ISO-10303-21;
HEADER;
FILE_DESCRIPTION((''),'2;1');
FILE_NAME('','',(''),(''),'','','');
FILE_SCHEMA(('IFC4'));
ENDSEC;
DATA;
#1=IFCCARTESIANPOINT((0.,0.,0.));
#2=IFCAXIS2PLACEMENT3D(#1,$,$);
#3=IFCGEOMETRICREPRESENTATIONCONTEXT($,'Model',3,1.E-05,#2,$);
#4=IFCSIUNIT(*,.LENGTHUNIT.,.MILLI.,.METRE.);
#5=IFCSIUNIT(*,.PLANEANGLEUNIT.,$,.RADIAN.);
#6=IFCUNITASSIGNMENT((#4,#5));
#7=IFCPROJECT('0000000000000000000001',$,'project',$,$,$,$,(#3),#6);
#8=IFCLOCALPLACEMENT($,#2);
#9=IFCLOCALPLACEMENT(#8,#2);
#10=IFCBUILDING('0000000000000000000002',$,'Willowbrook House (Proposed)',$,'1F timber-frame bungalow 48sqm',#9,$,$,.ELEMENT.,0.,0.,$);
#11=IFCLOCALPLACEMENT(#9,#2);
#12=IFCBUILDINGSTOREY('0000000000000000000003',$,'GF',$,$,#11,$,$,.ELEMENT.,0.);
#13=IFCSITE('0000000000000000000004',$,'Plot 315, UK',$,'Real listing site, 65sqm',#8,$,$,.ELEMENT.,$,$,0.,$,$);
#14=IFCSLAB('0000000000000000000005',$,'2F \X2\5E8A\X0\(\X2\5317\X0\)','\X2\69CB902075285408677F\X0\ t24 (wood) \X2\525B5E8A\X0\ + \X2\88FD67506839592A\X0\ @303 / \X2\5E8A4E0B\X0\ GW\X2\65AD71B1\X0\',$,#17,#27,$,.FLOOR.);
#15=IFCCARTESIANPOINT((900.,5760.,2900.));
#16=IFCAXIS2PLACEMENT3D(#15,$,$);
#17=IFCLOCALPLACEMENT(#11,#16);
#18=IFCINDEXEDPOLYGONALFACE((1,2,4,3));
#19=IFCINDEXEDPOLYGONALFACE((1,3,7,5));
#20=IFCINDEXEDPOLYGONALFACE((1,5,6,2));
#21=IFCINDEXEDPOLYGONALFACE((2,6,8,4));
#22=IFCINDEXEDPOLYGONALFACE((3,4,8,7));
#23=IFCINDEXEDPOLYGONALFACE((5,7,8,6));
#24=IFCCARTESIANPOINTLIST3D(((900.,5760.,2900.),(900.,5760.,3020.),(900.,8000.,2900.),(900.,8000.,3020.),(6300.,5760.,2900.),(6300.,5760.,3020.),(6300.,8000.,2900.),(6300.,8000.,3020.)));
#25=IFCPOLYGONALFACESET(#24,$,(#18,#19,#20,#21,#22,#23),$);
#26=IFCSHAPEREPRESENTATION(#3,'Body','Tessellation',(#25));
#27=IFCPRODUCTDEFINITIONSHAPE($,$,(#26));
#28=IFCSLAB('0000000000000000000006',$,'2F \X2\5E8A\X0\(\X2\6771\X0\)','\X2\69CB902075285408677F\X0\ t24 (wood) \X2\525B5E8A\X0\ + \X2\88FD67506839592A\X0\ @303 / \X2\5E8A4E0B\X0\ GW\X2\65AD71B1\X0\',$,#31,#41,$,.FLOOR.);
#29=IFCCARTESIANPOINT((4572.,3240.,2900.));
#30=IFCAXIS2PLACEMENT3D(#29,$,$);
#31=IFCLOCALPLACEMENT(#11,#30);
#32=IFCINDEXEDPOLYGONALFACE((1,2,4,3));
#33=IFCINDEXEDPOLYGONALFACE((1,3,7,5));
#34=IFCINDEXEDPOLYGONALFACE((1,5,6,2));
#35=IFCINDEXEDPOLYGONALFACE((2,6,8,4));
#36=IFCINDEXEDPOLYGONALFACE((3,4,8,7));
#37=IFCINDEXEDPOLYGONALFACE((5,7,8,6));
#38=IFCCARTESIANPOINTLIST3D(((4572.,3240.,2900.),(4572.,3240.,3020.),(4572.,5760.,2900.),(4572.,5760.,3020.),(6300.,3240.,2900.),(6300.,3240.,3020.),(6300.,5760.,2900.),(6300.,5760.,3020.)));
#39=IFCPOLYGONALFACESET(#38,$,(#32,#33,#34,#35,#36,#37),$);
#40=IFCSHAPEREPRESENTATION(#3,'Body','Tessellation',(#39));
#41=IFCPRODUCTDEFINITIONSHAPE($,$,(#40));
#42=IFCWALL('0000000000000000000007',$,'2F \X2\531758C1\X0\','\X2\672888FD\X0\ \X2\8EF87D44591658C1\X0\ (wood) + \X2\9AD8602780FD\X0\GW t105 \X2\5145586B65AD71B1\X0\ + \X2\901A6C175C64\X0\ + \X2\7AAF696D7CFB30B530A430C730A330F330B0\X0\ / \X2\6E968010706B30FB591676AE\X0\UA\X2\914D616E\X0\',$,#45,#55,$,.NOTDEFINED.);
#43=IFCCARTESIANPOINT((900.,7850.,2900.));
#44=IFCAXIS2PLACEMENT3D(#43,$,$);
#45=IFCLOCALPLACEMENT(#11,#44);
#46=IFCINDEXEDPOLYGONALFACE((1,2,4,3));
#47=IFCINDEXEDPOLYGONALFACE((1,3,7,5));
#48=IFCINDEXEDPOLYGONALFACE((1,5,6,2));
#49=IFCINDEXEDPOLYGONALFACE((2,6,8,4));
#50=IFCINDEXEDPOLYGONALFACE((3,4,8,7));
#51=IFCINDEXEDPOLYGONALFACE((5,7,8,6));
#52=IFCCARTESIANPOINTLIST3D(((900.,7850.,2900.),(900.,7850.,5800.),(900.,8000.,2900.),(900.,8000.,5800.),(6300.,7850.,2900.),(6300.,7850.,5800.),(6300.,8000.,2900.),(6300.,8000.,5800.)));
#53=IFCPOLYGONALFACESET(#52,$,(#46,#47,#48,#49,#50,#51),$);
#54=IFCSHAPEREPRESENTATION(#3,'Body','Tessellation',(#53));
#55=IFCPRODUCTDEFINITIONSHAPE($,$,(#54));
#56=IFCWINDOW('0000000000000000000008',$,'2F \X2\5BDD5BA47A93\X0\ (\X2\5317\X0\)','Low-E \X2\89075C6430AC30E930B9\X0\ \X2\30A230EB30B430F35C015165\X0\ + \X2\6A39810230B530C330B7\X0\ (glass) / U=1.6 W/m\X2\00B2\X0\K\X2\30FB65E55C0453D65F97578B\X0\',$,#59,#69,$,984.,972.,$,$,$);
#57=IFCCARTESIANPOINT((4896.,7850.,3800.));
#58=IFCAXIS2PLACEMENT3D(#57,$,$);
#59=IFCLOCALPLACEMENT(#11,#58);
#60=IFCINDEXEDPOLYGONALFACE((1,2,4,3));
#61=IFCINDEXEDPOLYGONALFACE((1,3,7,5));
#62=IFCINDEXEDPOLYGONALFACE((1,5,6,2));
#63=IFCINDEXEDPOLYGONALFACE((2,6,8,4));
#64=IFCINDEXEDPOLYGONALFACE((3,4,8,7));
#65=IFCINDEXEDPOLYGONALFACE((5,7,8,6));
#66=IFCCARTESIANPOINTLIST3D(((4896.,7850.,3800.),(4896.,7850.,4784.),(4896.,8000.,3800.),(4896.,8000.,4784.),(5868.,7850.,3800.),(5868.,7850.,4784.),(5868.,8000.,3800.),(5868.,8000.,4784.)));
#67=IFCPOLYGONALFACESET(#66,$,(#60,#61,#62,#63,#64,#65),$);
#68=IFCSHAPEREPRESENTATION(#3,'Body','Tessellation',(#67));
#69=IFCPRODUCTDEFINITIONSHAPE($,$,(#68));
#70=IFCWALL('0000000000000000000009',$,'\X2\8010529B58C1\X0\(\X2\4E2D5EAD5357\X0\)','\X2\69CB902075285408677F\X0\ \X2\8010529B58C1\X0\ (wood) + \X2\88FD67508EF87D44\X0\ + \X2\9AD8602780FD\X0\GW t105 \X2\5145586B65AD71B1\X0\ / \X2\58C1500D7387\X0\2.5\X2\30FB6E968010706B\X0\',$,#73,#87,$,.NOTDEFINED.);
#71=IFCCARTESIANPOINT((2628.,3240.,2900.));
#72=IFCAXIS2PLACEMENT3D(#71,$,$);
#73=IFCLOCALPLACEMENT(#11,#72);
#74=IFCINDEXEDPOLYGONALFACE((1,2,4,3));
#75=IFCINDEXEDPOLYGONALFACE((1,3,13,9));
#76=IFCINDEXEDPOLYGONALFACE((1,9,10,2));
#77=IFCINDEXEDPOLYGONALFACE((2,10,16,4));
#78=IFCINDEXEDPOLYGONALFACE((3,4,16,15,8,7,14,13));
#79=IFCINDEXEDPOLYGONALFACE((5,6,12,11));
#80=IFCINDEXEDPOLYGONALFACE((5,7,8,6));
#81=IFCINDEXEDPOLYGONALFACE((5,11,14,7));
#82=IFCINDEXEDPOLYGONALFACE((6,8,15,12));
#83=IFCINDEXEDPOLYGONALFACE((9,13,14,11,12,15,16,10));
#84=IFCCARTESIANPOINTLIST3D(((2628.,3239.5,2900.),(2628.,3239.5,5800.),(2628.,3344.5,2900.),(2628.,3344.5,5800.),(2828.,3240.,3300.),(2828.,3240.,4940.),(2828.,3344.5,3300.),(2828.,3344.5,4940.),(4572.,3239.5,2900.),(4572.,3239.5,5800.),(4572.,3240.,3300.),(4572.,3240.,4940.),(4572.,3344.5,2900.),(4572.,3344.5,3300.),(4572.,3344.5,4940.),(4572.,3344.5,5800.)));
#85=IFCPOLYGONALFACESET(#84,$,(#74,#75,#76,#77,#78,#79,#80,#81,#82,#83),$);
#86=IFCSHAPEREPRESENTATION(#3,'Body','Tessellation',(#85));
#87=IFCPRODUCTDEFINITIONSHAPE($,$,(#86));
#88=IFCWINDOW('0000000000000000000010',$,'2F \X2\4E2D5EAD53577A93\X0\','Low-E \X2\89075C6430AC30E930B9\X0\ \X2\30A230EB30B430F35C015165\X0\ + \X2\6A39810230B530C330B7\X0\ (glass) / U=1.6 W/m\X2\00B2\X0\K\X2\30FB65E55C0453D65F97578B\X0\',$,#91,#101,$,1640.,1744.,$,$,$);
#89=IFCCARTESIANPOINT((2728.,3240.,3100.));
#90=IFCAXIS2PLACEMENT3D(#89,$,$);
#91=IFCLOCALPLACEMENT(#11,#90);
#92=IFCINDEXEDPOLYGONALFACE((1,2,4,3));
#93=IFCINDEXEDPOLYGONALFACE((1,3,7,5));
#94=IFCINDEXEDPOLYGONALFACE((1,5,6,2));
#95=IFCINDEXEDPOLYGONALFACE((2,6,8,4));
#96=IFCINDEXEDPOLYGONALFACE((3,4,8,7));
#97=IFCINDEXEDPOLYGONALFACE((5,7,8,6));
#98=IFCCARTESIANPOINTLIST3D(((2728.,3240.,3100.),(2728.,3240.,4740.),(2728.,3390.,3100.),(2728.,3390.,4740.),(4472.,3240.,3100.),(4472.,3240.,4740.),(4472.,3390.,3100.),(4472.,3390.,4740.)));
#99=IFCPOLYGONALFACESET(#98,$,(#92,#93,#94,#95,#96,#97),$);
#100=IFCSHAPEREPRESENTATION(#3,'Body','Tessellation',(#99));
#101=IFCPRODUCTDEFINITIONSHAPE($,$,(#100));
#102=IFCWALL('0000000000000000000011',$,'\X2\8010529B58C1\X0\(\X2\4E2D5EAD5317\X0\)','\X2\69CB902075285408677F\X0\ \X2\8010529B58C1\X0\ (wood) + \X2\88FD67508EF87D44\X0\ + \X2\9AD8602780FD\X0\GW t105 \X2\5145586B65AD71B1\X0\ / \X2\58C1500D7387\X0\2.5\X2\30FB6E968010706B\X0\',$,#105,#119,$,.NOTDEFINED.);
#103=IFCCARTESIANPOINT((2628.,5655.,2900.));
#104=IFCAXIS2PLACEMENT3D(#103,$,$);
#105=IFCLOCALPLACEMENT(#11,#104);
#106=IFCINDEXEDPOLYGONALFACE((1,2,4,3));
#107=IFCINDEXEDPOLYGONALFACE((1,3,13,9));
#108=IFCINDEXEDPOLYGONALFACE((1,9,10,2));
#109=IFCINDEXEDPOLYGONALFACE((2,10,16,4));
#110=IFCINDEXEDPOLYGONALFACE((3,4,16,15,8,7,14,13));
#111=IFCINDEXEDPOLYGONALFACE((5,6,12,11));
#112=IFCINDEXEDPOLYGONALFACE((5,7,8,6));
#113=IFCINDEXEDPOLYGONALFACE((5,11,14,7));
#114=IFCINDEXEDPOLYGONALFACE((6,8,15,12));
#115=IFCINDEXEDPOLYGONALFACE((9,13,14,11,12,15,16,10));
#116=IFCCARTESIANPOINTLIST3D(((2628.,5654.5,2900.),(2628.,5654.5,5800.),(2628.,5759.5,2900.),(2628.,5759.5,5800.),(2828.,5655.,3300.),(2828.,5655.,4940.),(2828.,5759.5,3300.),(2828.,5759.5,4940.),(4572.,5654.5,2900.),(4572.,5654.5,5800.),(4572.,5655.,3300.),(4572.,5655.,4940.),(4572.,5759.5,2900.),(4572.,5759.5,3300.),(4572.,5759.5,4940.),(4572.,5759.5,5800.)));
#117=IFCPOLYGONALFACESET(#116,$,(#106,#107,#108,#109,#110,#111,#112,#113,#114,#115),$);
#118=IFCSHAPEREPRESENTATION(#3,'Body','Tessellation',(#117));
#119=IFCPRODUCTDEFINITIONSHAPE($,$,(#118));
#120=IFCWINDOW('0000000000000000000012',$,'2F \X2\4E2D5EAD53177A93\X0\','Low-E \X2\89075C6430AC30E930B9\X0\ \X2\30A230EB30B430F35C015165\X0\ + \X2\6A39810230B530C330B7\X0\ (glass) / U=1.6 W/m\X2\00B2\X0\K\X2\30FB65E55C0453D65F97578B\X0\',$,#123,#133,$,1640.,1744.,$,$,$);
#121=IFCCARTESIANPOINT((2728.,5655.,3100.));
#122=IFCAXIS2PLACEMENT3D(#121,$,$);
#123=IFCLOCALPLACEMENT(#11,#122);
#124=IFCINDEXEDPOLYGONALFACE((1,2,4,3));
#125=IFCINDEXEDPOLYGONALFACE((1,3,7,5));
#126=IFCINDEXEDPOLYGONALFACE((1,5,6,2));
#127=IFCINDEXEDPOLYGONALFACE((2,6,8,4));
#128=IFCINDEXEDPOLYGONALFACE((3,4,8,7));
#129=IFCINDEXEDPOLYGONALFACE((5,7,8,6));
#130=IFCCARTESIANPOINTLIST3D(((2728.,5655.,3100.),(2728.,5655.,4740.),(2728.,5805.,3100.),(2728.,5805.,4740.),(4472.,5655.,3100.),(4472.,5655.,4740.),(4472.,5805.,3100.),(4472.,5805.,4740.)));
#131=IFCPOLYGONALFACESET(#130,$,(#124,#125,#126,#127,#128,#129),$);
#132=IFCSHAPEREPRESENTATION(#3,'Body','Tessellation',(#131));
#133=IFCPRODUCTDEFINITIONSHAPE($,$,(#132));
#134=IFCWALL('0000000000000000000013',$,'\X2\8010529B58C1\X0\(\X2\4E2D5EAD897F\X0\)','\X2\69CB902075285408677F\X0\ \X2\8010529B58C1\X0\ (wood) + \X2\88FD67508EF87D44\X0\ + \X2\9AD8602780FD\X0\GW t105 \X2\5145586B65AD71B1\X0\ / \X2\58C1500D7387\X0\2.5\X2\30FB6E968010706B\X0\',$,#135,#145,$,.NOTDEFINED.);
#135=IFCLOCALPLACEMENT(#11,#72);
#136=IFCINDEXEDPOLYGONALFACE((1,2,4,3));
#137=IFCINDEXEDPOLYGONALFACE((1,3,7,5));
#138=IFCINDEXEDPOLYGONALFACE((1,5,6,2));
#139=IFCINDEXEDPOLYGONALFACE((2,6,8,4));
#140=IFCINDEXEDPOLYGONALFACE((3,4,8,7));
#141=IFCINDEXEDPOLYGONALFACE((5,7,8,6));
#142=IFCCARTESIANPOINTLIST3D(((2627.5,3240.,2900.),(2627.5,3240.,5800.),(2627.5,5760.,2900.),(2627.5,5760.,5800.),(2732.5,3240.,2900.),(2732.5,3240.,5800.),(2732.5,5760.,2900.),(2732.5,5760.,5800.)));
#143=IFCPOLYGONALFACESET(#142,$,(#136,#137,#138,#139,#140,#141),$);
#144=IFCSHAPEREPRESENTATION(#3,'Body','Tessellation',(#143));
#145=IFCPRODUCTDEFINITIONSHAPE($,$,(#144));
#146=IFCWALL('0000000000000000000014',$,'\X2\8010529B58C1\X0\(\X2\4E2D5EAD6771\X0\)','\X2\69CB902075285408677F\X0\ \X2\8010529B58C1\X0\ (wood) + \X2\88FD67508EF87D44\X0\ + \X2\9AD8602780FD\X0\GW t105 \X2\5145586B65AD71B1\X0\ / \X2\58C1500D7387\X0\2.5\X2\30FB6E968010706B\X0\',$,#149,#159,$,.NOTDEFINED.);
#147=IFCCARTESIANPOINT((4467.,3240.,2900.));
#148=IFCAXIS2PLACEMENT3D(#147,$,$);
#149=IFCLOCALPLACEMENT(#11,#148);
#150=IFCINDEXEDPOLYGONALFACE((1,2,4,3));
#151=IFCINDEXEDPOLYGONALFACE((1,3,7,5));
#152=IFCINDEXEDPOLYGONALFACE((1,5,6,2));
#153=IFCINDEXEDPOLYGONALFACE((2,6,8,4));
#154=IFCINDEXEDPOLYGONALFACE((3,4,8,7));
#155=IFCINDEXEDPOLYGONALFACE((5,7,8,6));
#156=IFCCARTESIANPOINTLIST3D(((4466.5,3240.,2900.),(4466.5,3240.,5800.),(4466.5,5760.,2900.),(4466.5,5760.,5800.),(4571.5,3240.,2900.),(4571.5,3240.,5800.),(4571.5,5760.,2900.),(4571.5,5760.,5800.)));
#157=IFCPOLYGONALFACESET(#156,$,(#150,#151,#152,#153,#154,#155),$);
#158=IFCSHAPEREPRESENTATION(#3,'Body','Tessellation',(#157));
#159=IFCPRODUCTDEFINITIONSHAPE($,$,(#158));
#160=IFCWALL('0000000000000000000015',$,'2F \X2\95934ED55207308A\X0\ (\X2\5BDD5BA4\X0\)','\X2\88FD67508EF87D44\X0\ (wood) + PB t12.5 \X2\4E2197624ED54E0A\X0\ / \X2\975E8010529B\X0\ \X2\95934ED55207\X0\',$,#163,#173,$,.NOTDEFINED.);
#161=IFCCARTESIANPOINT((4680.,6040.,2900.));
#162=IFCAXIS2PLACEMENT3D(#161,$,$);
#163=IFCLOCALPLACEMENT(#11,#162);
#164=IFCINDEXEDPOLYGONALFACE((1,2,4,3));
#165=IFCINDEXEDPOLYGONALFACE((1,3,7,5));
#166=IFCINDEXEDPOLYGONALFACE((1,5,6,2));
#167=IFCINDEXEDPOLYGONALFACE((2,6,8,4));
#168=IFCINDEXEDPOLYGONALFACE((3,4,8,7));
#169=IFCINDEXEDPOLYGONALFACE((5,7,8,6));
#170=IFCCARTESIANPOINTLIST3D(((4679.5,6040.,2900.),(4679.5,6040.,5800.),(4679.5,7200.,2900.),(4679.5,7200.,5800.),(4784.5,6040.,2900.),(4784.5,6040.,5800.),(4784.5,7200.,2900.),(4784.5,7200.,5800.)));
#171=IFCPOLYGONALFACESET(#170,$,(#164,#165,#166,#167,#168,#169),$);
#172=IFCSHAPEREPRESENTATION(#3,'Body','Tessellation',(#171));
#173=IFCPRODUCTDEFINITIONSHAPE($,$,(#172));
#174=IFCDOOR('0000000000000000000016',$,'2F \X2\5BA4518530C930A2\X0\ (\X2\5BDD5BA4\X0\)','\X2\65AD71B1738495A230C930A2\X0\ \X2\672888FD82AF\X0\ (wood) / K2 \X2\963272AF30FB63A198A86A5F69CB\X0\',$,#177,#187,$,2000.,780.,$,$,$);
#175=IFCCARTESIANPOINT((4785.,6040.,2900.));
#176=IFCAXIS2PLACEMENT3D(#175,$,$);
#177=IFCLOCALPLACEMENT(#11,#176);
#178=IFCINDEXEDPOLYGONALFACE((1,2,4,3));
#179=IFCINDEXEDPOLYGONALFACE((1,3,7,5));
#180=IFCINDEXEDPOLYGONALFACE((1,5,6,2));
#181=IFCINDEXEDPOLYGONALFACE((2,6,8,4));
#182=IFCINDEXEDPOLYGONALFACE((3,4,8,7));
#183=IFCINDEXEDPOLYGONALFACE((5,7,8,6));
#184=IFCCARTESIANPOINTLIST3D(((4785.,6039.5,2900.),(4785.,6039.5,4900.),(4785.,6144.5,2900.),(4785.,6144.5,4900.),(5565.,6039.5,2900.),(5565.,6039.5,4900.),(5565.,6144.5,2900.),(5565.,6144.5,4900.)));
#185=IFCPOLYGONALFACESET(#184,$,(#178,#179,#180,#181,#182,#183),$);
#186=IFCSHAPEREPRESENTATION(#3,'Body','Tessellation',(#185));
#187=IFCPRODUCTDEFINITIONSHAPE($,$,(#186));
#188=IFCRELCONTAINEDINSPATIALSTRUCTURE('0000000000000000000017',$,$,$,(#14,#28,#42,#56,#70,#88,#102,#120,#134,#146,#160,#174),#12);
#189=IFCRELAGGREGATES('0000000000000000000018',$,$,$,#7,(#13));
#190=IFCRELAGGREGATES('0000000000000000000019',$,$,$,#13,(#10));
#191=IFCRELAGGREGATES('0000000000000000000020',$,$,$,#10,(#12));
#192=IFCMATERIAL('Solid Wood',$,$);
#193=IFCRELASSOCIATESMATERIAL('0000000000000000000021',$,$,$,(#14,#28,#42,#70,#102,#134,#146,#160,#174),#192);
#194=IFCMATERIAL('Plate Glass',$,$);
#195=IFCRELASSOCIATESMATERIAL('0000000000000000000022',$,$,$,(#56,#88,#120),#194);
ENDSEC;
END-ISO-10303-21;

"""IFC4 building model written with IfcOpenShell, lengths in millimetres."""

from ifc_helpers import new_model, si_unit, frame, frame_2d, origin, place, context, project, spatial, rectangle, extrude, material, element, fill, save


model = new_model("IFC4")

# Units and contexts
model_context = context("Model", 3, precision=1e-05, world=origin())
ifc_project = project(units=[si_unit("LENGTHUNIT", "METRE", prefix="MILLI"), si_unit("PLANEANGLEUNIT", "RADIAN")], contexts=[model_context])

# Site, building, storey
site_placement = place(None, origin())
site = spatial("IfcSite", under=ifc_project, at=site_placement, Name="Plot 315, UK", ObjectType="Real listing site, 65sqm", CompositionType="ELEMENT", RefElevation=0.0)
building_placement = place(site_placement, origin())
building = spatial("IfcBuilding", under=site, at=building_placement, Name="Willowbrook House (Proposed)", ObjectType="1F timber-frame bungalow 48sqm", CompositionType="ELEMENT", ElevationOfRefHeight=0.0, ElevationOfTerrain=0.0)
storey_placement = place(building_placement, origin())
storey = spatial("IfcBuildingStorey", under=building, at=storey_placement, Name="GF", CompositionType="ELEMENT", Elevation=0.0)

# Slabs
ifc_material_1 = material(Name="Solid Wood")
slab_1_placement = place(storey_placement, frame((900.0, 5760.0, 2900.0)))
element("IfcSlab", 1, at=slab_1_placement, inside=storey, material=ifc_material_1, Name="2F 床(北)", Description="構造用合板 t24 (wood) 剛床 + 製材根太 @303 / 床下 GW断熱", PredefinedType="FLOOR", context=model_context, shape_type="SweptSolid", body=[
    extrude(rectangle(XDim=5400.0, YDim=2240.0, at=frame_2d((2700.0, 1120.0))), frame((900.0, 5760.0, 2900.0)), (0.0, 0.0, 1.0), 120.0),
])
slab_2_placement = place(storey_placement, frame((4572.0, 3240.0, 2900.0)))
element("IfcSlab", 2, at=slab_2_placement, inside=storey, material=ifc_material_1, Name="2F 床(東)", Description="構造用合板 t24 (wood) 剛床 + 製材根太 @303 / 床下 GW断熱", PredefinedType="FLOOR", context=model_context, shape_type="SweptSolid", body=[
    extrude(rectangle(XDim=1728.0, YDim=2520.0, at=frame_2d((864.0, 1260.0))), frame((4572.0, 3240.0, 2900.0)), (0.0, 0.0, 1.0), 120.0),
])

# Walls, openings, windows
wall_1_placement = place(storey_placement, frame((900.0, 7850.0, 2900.0)))
wall_1 = element("IfcWall", 3, at=wall_1_placement, inside=storey, material=ifc_material_1, Name="2F 北壁", Description="木製 軸組外壁 (wood) + 高性能GW t105 充填断熱 + 通気層 + 窯業系サイディング / 準耐火・外皮UA配慮", PredefinedType="NOTDEFINED", context=model_context, shape_type="SweptSolid", body=[
    extrude(rectangle(XDim=5400.0, YDim=150.0, at=frame_2d((2700.0, 75.0))), frame((900.0, 7850.0, 2900.0)), (0.0, 0.0, 1.0), 2900.0),
])
opening_1_placement = place(storey_placement, frame((4896.0, 7850.0, 3800.0)))
opening_1 = element("IfcOpeningElement", 4, at=opening_1_placement, cuts=wall_1, PredefinedType="NOTDEFINED", context=model_context, shape_type="SweptSolid", body=[
    extrude(rectangle(XDim=972.0, YDim=150.0, at=frame_2d((486.0, 75.0))), frame((4896.0, 7850.0, 3800.0)), (0.0, 0.0, 1.0), 984.0),
])
ifc_material_2 = material(Name="Plate Glass")
window_1_placement = place(storey_placement, frame((4896.0, 7850.0, 3800.0)))
window_1 = element("IfcWindow", 5, at=window_1_placement, inside=storey, material=ifc_material_2, Name="2F 寝室窓 (北)", Description="Low-E 複層ガラス アルゴン封入 + 樹脂サッシ (glass) / U=1.6 W/m²K・日射取得型", OverallHeight=984.0, OverallWidth=972.0, context=model_context, shape_type="SweptSolid", body=[
    extrude(rectangle(XDim=972.0, YDim=150.0, at=frame_2d((486.0, 75.0))), frame((4896.0, 7850.0, 3800.0)), (0.0, 0.0, 1.0), 984.0),
])
fill(opening_1, window_1)
wall_2_placement = place(storey_placement, frame((2628.0, 3240.0, 2900.0)))
wall_2 = element("IfcWall", 6, at=wall_2_placement, inside=storey, material=ifc_material_1, Name="耐力壁(中庭南)", Description="構造用合板 耐力壁 (wood) + 製材軸組 + 高性能GW t105 充填断熱 / 壁倍率2.5・準耐火", PredefinedType="NOTDEFINED", context=model_context, shape_type="SweptSolid", body=[
    extrude(rectangle(XDim=1944.0, YDim=105.0, at=frame_2d((972.0, 52.0))), frame((2628.0, 3240.0, 2900.0)), (0.0, 0.0, 1.0), 2900.0),
])
opening_2_placement = place(storey_placement, frame((2728.0, 3240.0, 3100.0)))
opening_2 = element("IfcOpeningElement", 7, at=opening_2_placement, cuts=wall_2, PredefinedType="NOTDEFINED", context=model_context, shape_type="SweptSolid", body=[
    extrude(rectangle(XDim=1744.0, YDim=150.0, at=frame_2d((872.0, 75.0))), frame((2728.0, 3240.0, 3100.0)), (0.0, 0.0, 1.0), 1640.0),
])
window_2_placement = place(storey_placement, frame((2728.0, 3240.0, 3100.0)))
window_2 = element("IfcWindow", 8, at=window_2_placement, inside=storey, material=ifc_material_2, Name="2F 中庭南窓", Description="Low-E 複層ガラス アルゴン封入 + 樹脂サッシ (glass) / U=1.6 W/m²K・日射取得型", OverallHeight=1640.0, OverallWidth=1744.0, context=model_context, shape_type="SweptSolid", body=[
    extrude(rectangle(XDim=1744.0, YDim=150.0, at=frame_2d((872.0, 75.0))), frame((2728.0, 3240.0, 3100.0)), (0.0, 0.0, 1.0), 1640.0),
])
fill(opening_2, window_2)
wall_3_placement = place(storey_placement, frame((2628.0, 5655.0, 2900.0)))
wall_3 = element("IfcWall", 9, at=wall_3_placement, inside=storey, material=ifc_material_1, Name="耐力壁(中庭北)", Description="構造用合板 耐力壁 (wood) + 製材軸組 + 高性能GW t105 充填断熱 / 壁倍率2.5・準耐火", PredefinedType="NOTDEFINED", context=model_context, shape_type="SweptSolid", body=[
    extrude(rectangle(XDim=1944.0, YDim=105.0, at=frame_2d((972.0, 52.0))), frame((2628.0, 5655.0, 2900.0)), (0.0, 0.0, 1.0), 2900.0),
])
opening_3_placement = place(storey_placement, frame((2728.0, 5655.0, 3100.0)))
opening_3 = element("IfcOpeningElement", 10, at=opening_3_placement, cuts=wall_3, PredefinedType="NOTDEFINED", context=model_context, shape_type="SweptSolid", body=[
    extrude(rectangle(XDim=1744.0, YDim=150.0, at=frame_2d((872.0, 75.0))), frame((2728.0, 5655.0, 3100.0)), (0.0, 0.0, 1.0), 1640.0),
])
window_3_placement = place(storey_placement, frame((2728.0, 5655.0, 3100.0)))
window_3 = element("IfcWindow", 11, at=window_3_placement, inside=storey, material=ifc_material_2, Name="2F 中庭北窓", Description="Low-E 複層ガラス アルゴン封入 + 樹脂サッシ (glass) / U=1.6 W/m²K・日射取得型", OverallHeight=1640.0, OverallWidth=1744.0, context=model_context, shape_type="SweptSolid", body=[
    extrude(rectangle(XDim=1744.0, YDim=150.0, at=frame_2d((872.0, 75.0))), frame((2728.0, 5655.0, 3100.0)), (0.0, 0.0, 1.0), 1640.0),
])
fill(opening_3, window_3)

# Walls
wall_4_placement = place(storey_placement, frame((2628.0, 3240.0, 2900.0)))
element("IfcWall", 12, at=wall_4_placement, inside=storey, material=ifc_material_1, Name="耐力壁(中庭西)", Description="構造用合板 耐力壁 (wood) + 製材軸組 + 高性能GW t105 充填断熱 / 壁倍率2.5・準耐火", PredefinedType="NOTDEFINED", context=model_context, shape_type="SweptSolid", body=[
    extrude(rectangle(XDim=105.0, YDim=2520.0, at=frame_2d((52.0, 1260.0))), frame((2628.0, 3240.0, 2900.0)), (0.0, 0.0, 1.0), 2900.0),
])
wall_5_placement = place(storey_placement, frame((4467.0, 3240.0, 2900.0)))
element("IfcWall", 13, at=wall_5_placement, inside=storey, material=ifc_material_1, Name="耐力壁(中庭東)", Description="構造用合板 耐力壁 (wood) + 製材軸組 + 高性能GW t105 充填断熱 / 壁倍率2.5・準耐火", PredefinedType="NOTDEFINED", context=model_context, shape_type="SweptSolid", body=[
    extrude(rectangle(XDim=105.0, YDim=2520.0, at=frame_2d((52.0, 1260.0))), frame((4467.0, 3240.0, 2900.0)), (0.0, 0.0, 1.0), 2900.0),
])
wall_6_placement = place(storey_placement, frame((4680.0, 6040.0, 2900.0)))
element("IfcWall", 14, at=wall_6_placement, inside=storey, material=ifc_material_1, Name="2F 間仕切り (寝室)", Description="製材軸組 (wood) + PB t12.5 両面仕上 / 非耐力 間仕切", PredefinedType="NOTDEFINED", context=model_context, shape_type="SweptSolid", body=[
    extrude(rectangle(XDim=105.0, YDim=1160.0, at=frame_2d((52.0, 580.0))), frame((4680.0, 6040.0, 2900.0)), (0.0, 0.0, 1.0), 2900.0),
])

# Door
door_placement = place(storey_placement, frame((4785.0, 6040.0, 2900.0)))
element("IfcDoor", 15, at=door_placement, inside=storey, material=ifc_material_1, Name="2F 室内ドア (寝室)", Description="断熱玄関ドア 木製芯 (wood) / K2 防犯・採風機構", OverallHeight=2000.0, OverallWidth=780.0, context=model_context, shape_type="SweptSolid", body=[
    extrude(rectangle(XDim=780.0, YDim=105.0, at=frame_2d((390.0, 52.0))), frame((4785.0, 6040.0, 2900.0)), (0.0, 0.0, 1.0), 2000.0),
])

save(model, "model.ifc")
